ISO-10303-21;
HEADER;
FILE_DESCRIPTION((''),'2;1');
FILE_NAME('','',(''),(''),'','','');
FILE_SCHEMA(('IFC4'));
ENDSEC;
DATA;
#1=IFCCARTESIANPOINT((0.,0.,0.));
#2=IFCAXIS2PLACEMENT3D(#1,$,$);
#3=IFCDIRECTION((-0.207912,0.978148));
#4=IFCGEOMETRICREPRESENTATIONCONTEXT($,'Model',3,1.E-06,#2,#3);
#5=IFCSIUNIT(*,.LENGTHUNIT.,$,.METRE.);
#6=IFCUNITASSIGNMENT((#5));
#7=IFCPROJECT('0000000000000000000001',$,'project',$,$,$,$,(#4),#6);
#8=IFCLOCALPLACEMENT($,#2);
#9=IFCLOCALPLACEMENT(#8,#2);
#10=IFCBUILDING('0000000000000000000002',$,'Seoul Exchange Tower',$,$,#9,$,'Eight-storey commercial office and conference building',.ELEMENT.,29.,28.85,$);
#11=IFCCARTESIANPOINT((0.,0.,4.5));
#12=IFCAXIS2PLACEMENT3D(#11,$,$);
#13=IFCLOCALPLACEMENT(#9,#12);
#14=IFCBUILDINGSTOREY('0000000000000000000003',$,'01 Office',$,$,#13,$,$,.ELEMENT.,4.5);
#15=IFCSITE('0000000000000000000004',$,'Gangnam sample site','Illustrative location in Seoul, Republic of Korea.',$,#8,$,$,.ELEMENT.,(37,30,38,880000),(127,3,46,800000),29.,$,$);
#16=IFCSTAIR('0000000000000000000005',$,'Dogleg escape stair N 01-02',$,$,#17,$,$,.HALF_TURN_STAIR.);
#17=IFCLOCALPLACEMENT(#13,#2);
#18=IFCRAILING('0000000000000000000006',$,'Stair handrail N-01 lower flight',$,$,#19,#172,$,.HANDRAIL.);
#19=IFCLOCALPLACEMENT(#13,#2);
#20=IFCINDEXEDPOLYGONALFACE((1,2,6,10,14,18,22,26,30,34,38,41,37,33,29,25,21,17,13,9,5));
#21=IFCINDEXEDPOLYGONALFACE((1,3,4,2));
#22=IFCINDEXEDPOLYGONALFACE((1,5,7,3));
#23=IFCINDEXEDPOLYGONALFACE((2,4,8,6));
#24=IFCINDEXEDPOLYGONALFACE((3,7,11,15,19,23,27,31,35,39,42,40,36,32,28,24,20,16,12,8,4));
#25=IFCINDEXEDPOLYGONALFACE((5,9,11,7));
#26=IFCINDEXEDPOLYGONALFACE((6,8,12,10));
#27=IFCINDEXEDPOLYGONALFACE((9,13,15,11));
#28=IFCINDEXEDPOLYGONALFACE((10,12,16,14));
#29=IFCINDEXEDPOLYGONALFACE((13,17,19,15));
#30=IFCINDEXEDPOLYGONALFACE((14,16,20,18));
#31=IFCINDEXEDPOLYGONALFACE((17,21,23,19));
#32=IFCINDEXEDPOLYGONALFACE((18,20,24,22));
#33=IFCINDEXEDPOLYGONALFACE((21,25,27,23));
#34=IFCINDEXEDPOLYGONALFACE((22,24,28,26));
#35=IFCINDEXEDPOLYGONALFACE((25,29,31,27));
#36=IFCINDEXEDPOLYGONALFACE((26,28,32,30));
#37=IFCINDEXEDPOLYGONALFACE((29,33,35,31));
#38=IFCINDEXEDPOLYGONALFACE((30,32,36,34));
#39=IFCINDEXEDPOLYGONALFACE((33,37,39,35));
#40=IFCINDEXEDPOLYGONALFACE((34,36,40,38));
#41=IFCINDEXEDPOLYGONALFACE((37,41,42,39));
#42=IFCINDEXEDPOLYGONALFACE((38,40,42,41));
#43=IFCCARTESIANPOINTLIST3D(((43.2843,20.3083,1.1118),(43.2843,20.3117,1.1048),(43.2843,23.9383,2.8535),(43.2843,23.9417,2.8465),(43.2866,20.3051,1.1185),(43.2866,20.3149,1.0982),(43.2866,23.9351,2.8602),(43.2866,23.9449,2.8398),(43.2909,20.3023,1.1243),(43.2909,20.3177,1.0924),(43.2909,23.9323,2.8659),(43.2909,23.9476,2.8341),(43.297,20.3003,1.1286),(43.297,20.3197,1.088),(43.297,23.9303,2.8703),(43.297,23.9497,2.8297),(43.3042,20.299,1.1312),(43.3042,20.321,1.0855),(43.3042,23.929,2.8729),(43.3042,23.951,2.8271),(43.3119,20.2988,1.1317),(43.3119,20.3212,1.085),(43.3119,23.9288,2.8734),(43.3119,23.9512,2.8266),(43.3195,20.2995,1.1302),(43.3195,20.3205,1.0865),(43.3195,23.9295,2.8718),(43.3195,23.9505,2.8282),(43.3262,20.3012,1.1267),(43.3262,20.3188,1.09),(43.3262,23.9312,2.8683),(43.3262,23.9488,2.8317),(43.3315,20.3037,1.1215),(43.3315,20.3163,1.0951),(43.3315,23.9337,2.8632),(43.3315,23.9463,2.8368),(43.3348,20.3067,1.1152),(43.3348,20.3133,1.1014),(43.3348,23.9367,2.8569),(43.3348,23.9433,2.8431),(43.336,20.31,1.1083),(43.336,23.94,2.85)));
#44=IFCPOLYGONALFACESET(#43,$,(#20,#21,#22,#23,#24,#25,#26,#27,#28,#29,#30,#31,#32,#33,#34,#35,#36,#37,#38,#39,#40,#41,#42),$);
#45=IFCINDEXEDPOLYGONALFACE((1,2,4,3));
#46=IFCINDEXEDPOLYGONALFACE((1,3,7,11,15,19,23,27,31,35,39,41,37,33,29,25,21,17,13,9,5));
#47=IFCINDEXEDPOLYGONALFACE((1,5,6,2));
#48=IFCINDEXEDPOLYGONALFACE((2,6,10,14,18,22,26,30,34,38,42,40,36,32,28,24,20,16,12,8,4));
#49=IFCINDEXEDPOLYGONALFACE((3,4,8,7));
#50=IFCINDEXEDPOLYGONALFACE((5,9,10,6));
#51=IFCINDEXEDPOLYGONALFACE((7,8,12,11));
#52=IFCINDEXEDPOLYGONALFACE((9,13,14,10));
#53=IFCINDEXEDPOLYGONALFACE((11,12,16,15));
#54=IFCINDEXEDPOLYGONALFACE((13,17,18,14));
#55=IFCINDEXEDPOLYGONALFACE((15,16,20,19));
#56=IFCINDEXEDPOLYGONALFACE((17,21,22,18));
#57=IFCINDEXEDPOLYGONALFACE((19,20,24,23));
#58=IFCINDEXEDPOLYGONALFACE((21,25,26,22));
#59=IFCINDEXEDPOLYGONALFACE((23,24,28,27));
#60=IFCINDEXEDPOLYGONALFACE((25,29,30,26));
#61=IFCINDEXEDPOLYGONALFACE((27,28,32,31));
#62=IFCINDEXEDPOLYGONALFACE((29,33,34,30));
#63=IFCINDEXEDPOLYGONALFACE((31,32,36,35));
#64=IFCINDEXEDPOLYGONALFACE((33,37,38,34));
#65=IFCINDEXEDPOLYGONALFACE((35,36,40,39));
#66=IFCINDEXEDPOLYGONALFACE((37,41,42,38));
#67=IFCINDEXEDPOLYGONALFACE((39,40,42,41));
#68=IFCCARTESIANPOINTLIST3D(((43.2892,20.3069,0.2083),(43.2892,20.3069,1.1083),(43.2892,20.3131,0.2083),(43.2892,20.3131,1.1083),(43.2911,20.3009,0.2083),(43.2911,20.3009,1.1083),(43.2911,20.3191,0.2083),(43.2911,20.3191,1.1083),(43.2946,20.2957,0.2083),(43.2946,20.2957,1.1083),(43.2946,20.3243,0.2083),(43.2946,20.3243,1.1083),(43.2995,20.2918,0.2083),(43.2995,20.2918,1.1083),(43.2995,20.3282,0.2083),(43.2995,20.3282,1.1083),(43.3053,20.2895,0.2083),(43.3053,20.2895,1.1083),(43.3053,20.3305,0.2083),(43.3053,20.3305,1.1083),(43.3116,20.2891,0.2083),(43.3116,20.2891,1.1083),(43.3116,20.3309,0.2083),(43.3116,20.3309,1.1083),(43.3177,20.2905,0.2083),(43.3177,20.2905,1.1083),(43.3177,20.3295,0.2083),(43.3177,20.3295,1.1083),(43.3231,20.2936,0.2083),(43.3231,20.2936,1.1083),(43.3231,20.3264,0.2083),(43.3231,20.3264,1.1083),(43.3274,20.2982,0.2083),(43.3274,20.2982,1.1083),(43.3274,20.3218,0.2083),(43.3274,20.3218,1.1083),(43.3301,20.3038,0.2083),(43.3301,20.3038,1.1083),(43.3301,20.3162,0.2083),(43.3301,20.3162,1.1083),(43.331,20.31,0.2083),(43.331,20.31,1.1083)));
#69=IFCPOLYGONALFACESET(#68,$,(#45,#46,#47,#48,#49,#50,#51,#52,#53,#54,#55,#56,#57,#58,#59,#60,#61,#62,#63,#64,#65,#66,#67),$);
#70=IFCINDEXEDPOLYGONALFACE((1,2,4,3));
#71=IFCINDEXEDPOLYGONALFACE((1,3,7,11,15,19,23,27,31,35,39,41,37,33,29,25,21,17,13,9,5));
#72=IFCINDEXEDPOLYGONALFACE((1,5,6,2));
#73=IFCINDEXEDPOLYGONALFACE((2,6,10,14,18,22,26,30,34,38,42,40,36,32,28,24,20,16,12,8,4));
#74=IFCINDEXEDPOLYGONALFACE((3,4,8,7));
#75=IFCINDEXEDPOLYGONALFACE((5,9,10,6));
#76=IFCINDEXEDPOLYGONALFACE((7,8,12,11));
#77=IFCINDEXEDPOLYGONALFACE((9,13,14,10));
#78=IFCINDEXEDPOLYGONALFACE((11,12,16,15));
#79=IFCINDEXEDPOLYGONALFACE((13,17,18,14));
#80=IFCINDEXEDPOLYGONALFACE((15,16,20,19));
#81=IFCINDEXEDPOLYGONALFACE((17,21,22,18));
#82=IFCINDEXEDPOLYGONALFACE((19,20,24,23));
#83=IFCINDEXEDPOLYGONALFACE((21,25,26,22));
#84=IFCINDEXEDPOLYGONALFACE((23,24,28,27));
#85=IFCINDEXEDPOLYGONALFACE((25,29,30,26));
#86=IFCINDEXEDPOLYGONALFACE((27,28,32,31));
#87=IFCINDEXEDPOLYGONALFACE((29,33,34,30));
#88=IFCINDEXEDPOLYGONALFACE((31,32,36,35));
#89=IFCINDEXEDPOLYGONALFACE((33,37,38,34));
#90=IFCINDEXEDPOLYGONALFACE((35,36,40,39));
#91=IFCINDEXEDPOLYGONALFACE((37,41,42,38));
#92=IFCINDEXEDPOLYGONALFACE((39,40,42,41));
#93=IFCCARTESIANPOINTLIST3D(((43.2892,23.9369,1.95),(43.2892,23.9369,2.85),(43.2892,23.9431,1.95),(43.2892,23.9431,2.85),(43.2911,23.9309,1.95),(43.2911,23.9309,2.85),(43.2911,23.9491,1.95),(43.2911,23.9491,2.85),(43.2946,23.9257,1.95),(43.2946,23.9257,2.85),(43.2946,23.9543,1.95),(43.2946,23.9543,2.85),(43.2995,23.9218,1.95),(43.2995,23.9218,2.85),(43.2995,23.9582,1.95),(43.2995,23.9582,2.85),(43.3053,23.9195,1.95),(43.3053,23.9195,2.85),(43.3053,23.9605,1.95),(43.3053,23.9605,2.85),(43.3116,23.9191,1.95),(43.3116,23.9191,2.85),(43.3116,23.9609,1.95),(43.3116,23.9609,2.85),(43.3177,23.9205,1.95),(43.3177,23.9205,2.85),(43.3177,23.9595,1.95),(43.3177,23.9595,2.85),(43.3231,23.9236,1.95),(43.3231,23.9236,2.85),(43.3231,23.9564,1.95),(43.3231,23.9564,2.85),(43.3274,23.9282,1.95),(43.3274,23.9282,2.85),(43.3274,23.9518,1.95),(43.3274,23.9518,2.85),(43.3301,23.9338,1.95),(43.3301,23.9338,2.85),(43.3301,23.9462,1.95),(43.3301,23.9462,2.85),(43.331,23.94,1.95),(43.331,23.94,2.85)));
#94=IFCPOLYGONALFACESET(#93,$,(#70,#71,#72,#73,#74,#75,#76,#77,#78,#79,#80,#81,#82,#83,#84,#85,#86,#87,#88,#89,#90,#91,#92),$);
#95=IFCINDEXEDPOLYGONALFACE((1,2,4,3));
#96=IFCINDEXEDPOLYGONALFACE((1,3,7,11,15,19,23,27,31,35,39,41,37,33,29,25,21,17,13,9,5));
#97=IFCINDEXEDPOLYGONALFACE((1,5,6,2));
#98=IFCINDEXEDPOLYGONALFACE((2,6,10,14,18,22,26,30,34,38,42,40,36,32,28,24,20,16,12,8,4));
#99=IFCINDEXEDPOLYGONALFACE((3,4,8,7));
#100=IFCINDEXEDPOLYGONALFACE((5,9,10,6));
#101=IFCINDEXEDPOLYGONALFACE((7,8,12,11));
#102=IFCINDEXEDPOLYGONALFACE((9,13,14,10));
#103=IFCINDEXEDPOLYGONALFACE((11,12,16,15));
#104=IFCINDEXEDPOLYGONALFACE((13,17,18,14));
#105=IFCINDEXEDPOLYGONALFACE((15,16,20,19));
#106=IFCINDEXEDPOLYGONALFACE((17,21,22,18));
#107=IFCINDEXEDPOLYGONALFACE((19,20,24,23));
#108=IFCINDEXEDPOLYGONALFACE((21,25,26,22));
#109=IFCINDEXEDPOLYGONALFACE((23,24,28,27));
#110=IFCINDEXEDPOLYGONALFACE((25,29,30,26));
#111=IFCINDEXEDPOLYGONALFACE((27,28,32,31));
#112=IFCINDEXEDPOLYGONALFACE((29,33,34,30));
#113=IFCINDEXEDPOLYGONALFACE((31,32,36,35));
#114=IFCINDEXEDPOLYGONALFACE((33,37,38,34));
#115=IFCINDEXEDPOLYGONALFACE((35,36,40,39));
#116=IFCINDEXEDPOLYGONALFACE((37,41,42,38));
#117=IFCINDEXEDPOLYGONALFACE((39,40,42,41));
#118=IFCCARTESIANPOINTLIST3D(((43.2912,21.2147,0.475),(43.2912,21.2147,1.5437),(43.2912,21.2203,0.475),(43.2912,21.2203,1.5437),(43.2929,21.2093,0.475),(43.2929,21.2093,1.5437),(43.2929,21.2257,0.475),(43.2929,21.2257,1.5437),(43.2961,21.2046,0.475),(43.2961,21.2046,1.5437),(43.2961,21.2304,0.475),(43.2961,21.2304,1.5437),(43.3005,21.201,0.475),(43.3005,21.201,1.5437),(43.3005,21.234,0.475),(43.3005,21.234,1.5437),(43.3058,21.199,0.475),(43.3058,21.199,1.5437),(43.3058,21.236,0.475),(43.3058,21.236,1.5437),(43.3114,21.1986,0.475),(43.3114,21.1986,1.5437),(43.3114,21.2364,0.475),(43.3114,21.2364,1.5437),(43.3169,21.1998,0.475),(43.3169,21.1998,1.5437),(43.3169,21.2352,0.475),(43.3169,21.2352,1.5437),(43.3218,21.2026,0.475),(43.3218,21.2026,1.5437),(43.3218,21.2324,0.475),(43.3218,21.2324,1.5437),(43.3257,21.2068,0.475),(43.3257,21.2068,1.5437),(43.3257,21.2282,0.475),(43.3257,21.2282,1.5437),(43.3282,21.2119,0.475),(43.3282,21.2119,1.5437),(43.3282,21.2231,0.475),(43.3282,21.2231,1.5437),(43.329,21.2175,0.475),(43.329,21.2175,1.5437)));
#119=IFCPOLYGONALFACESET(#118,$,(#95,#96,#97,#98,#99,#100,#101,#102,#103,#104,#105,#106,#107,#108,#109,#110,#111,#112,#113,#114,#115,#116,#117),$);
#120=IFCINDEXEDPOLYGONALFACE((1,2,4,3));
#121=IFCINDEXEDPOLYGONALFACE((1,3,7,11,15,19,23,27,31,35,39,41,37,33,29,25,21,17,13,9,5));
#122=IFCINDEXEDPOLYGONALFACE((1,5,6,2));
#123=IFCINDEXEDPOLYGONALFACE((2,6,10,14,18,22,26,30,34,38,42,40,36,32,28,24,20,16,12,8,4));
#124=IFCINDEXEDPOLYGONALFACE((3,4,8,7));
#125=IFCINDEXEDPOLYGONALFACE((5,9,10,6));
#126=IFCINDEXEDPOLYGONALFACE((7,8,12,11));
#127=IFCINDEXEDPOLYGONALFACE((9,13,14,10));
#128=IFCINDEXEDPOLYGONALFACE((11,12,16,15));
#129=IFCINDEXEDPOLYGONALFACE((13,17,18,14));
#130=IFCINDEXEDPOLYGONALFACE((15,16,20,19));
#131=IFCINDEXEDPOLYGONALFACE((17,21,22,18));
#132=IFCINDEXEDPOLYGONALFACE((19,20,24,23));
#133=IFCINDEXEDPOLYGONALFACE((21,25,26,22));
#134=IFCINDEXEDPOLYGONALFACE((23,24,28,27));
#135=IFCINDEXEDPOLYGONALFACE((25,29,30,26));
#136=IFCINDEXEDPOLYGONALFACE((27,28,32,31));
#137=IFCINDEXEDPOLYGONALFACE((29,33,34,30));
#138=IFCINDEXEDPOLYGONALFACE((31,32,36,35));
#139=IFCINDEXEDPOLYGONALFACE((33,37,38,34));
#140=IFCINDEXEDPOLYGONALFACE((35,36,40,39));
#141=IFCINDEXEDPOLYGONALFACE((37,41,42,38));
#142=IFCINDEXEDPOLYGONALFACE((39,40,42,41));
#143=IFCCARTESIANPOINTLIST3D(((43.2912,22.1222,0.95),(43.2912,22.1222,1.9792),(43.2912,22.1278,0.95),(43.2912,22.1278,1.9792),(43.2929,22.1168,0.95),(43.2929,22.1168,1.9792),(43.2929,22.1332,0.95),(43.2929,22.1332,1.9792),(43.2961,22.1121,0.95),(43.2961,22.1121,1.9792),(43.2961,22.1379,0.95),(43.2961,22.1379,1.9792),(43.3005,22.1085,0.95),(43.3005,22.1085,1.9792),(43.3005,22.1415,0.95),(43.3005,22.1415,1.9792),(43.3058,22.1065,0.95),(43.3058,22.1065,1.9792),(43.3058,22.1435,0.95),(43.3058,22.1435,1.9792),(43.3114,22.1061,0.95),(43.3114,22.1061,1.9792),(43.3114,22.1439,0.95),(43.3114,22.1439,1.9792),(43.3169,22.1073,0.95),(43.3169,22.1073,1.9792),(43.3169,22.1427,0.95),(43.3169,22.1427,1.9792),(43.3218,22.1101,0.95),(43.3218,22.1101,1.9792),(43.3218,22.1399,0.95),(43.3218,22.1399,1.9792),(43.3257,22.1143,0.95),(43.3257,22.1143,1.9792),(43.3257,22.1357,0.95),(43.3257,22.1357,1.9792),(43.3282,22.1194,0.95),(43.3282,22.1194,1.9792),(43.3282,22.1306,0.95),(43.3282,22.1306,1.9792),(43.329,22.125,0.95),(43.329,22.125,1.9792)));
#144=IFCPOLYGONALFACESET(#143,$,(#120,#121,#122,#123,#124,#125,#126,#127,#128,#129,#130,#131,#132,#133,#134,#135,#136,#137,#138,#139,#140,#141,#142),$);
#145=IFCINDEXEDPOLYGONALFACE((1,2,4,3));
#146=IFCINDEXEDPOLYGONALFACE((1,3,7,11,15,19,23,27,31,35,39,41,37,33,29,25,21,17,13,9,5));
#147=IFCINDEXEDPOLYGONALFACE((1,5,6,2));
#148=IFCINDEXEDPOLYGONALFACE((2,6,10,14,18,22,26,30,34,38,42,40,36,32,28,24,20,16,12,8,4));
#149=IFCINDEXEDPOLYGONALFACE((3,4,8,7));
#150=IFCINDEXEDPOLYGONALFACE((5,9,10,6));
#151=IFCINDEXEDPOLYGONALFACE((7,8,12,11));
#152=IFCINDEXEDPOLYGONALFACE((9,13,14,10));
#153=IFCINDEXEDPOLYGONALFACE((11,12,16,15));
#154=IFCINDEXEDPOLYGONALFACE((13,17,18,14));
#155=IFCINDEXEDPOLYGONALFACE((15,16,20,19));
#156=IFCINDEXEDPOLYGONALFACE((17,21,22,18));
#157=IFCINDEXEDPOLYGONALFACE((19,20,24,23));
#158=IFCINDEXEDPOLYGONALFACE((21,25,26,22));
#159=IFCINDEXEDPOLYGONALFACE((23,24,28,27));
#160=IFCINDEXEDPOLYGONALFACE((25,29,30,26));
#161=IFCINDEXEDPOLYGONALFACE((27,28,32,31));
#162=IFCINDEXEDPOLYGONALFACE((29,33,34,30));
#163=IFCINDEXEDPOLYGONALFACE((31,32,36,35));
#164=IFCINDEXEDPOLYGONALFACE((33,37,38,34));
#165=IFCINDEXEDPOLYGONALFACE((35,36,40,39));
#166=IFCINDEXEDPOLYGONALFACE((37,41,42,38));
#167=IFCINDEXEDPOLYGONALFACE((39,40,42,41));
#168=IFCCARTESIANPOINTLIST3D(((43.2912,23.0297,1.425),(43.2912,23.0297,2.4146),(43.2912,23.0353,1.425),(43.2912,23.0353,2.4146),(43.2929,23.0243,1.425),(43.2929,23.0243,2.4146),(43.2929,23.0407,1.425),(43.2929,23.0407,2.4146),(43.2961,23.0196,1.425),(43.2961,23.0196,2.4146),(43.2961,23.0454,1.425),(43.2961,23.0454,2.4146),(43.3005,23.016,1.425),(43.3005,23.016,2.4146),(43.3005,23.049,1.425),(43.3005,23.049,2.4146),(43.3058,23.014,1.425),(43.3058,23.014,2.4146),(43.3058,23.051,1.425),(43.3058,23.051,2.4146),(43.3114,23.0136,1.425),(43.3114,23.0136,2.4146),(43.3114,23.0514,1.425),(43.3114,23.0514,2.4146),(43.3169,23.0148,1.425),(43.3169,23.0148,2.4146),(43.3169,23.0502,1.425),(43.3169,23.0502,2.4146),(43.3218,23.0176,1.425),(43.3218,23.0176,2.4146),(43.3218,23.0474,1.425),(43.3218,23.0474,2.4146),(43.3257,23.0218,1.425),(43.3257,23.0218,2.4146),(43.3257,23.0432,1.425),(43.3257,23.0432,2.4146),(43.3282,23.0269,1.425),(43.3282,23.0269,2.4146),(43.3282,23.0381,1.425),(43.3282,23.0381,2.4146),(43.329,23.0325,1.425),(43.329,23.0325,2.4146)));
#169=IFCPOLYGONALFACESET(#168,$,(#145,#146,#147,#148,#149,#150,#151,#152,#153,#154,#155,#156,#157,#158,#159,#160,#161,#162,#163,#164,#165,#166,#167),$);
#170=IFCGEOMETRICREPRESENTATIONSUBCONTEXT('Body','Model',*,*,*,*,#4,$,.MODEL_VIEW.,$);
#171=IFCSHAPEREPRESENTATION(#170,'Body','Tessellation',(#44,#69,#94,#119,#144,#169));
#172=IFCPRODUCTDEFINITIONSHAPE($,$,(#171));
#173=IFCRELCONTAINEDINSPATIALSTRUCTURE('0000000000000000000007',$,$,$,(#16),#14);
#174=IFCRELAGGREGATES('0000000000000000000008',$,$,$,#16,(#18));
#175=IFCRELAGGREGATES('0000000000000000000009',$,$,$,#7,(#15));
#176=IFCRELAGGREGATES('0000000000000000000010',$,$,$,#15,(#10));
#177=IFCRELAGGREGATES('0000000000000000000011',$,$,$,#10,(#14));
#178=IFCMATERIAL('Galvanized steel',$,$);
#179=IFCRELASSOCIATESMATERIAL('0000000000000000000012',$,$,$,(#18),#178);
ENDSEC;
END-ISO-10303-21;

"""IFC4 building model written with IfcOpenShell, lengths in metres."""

from ifc_helpers import new_model, si_unit, direction, frame, origin, place, context, subcontext, project, spatial, circle, extrude, material, element, aggregate, save


model = new_model("IFC4")

# Units and contexts
model_context = context("Model", 3, precision=1e-06, world=origin(), true_north=direction((-0.207912, 0.978148)))
body_context = subcontext(model_context, "Body", "Model", "MODEL_VIEW")
ifc_project = project(units=[si_unit("LENGTHUNIT", "METRE")], contexts=[model_context])

# Site, building, storey
site_placement = place(None, origin())
site = spatial("IfcSite", under=ifc_project, at=site_placement, Name="Gangnam sample site", Description="Illustrative location in Seoul, Republic of Korea.", CompositionType="ELEMENT", RefLatitude=(37, 30, 38, 880000), RefLongitude=(127, 3, 46, 800000), RefElevation=29.0)
building_placement = place(site_placement, origin())
building = spatial("IfcBuilding", under=site, at=building_placement, Name="Seoul Exchange Tower", LongName="Eight-storey commercial office and conference building", CompositionType="ELEMENT", ElevationOfRefHeight=29.0, ElevationOfTerrain=28.85)
storey_placement = place(building_placement, frame((0.0, 0.0, 4.5)))
storey = spatial("IfcBuildingStorey", under=building, at=storey_placement, Name="01 Office", CompositionType="ELEMENT", Elevation=4.5)

# Shared definitions
placement_1 = place(storey_placement, origin())

# Stair
stair_1 = element("IfcStair", 1, at=placement_1, inside=storey, Name="Dogleg escape stair N 01-02", PredefinedType="HALF_TURN_STAIR")
placement_2 = place(placement_1, origin())

# Railing
ifc_material_1 = material(Name="Galvanized steel")
railing_1 = element("IfcRailing", 2, at=placement_2, material=ifc_material_1, Name="Stair handrail N-01 lower flight", PredefinedType="HANDRAIL", context=body_context, shape_type="SweptSolid", body=[
    extrude(circle(Radius=0.026), frame((43.31, 20.31, 1.1083), z_axis=(0.0, 0.901594, 0.432583), x_axis=(1.0, 0.0, 0.0)), (0.0, 0.0, 1.0), 4.0262),
    extrude(circle(Radius=0.021), frame((43.31, 20.31, 0.2083), z_axis=(0.0, 0.0, 1.0), x_axis=(1.0, 0.0, 0.0)), (0.0, 0.0, 1.0), 0.9),
    extrude(circle(Radius=0.021), frame((43.31, 23.94, 1.95), z_axis=(0.0, 0.0, 1.0), x_axis=(1.0, 0.0, 0.0)), (0.0, 0.0, 1.0), 0.9),
    extrude(circle(Radius=0.019), frame((43.31, 21.2175, 0.475), z_axis=(0.0, 0.0, 1.0), x_axis=(1.0, 0.0, 0.0)), (0.0, 0.0, 1.0), 1.0688),
    extrude(circle(Radius=0.019), frame((43.31, 22.125, 0.95), z_axis=(0.0, 0.0, 1.0), x_axis=(1.0, 0.0, 0.0)), (0.0, 0.0, 1.0), 1.0292),
    extrude(circle(Radius=0.019), frame((43.31, 23.0325, 1.425), z_axis=(0.0, 0.0, 1.0), x_axis=(1.0, 0.0, 0.0)), (0.0, 0.0, 1.0), 0.9896),
])
aggregate(stair_1, [railing_1])

save(model, "model.ifc")
